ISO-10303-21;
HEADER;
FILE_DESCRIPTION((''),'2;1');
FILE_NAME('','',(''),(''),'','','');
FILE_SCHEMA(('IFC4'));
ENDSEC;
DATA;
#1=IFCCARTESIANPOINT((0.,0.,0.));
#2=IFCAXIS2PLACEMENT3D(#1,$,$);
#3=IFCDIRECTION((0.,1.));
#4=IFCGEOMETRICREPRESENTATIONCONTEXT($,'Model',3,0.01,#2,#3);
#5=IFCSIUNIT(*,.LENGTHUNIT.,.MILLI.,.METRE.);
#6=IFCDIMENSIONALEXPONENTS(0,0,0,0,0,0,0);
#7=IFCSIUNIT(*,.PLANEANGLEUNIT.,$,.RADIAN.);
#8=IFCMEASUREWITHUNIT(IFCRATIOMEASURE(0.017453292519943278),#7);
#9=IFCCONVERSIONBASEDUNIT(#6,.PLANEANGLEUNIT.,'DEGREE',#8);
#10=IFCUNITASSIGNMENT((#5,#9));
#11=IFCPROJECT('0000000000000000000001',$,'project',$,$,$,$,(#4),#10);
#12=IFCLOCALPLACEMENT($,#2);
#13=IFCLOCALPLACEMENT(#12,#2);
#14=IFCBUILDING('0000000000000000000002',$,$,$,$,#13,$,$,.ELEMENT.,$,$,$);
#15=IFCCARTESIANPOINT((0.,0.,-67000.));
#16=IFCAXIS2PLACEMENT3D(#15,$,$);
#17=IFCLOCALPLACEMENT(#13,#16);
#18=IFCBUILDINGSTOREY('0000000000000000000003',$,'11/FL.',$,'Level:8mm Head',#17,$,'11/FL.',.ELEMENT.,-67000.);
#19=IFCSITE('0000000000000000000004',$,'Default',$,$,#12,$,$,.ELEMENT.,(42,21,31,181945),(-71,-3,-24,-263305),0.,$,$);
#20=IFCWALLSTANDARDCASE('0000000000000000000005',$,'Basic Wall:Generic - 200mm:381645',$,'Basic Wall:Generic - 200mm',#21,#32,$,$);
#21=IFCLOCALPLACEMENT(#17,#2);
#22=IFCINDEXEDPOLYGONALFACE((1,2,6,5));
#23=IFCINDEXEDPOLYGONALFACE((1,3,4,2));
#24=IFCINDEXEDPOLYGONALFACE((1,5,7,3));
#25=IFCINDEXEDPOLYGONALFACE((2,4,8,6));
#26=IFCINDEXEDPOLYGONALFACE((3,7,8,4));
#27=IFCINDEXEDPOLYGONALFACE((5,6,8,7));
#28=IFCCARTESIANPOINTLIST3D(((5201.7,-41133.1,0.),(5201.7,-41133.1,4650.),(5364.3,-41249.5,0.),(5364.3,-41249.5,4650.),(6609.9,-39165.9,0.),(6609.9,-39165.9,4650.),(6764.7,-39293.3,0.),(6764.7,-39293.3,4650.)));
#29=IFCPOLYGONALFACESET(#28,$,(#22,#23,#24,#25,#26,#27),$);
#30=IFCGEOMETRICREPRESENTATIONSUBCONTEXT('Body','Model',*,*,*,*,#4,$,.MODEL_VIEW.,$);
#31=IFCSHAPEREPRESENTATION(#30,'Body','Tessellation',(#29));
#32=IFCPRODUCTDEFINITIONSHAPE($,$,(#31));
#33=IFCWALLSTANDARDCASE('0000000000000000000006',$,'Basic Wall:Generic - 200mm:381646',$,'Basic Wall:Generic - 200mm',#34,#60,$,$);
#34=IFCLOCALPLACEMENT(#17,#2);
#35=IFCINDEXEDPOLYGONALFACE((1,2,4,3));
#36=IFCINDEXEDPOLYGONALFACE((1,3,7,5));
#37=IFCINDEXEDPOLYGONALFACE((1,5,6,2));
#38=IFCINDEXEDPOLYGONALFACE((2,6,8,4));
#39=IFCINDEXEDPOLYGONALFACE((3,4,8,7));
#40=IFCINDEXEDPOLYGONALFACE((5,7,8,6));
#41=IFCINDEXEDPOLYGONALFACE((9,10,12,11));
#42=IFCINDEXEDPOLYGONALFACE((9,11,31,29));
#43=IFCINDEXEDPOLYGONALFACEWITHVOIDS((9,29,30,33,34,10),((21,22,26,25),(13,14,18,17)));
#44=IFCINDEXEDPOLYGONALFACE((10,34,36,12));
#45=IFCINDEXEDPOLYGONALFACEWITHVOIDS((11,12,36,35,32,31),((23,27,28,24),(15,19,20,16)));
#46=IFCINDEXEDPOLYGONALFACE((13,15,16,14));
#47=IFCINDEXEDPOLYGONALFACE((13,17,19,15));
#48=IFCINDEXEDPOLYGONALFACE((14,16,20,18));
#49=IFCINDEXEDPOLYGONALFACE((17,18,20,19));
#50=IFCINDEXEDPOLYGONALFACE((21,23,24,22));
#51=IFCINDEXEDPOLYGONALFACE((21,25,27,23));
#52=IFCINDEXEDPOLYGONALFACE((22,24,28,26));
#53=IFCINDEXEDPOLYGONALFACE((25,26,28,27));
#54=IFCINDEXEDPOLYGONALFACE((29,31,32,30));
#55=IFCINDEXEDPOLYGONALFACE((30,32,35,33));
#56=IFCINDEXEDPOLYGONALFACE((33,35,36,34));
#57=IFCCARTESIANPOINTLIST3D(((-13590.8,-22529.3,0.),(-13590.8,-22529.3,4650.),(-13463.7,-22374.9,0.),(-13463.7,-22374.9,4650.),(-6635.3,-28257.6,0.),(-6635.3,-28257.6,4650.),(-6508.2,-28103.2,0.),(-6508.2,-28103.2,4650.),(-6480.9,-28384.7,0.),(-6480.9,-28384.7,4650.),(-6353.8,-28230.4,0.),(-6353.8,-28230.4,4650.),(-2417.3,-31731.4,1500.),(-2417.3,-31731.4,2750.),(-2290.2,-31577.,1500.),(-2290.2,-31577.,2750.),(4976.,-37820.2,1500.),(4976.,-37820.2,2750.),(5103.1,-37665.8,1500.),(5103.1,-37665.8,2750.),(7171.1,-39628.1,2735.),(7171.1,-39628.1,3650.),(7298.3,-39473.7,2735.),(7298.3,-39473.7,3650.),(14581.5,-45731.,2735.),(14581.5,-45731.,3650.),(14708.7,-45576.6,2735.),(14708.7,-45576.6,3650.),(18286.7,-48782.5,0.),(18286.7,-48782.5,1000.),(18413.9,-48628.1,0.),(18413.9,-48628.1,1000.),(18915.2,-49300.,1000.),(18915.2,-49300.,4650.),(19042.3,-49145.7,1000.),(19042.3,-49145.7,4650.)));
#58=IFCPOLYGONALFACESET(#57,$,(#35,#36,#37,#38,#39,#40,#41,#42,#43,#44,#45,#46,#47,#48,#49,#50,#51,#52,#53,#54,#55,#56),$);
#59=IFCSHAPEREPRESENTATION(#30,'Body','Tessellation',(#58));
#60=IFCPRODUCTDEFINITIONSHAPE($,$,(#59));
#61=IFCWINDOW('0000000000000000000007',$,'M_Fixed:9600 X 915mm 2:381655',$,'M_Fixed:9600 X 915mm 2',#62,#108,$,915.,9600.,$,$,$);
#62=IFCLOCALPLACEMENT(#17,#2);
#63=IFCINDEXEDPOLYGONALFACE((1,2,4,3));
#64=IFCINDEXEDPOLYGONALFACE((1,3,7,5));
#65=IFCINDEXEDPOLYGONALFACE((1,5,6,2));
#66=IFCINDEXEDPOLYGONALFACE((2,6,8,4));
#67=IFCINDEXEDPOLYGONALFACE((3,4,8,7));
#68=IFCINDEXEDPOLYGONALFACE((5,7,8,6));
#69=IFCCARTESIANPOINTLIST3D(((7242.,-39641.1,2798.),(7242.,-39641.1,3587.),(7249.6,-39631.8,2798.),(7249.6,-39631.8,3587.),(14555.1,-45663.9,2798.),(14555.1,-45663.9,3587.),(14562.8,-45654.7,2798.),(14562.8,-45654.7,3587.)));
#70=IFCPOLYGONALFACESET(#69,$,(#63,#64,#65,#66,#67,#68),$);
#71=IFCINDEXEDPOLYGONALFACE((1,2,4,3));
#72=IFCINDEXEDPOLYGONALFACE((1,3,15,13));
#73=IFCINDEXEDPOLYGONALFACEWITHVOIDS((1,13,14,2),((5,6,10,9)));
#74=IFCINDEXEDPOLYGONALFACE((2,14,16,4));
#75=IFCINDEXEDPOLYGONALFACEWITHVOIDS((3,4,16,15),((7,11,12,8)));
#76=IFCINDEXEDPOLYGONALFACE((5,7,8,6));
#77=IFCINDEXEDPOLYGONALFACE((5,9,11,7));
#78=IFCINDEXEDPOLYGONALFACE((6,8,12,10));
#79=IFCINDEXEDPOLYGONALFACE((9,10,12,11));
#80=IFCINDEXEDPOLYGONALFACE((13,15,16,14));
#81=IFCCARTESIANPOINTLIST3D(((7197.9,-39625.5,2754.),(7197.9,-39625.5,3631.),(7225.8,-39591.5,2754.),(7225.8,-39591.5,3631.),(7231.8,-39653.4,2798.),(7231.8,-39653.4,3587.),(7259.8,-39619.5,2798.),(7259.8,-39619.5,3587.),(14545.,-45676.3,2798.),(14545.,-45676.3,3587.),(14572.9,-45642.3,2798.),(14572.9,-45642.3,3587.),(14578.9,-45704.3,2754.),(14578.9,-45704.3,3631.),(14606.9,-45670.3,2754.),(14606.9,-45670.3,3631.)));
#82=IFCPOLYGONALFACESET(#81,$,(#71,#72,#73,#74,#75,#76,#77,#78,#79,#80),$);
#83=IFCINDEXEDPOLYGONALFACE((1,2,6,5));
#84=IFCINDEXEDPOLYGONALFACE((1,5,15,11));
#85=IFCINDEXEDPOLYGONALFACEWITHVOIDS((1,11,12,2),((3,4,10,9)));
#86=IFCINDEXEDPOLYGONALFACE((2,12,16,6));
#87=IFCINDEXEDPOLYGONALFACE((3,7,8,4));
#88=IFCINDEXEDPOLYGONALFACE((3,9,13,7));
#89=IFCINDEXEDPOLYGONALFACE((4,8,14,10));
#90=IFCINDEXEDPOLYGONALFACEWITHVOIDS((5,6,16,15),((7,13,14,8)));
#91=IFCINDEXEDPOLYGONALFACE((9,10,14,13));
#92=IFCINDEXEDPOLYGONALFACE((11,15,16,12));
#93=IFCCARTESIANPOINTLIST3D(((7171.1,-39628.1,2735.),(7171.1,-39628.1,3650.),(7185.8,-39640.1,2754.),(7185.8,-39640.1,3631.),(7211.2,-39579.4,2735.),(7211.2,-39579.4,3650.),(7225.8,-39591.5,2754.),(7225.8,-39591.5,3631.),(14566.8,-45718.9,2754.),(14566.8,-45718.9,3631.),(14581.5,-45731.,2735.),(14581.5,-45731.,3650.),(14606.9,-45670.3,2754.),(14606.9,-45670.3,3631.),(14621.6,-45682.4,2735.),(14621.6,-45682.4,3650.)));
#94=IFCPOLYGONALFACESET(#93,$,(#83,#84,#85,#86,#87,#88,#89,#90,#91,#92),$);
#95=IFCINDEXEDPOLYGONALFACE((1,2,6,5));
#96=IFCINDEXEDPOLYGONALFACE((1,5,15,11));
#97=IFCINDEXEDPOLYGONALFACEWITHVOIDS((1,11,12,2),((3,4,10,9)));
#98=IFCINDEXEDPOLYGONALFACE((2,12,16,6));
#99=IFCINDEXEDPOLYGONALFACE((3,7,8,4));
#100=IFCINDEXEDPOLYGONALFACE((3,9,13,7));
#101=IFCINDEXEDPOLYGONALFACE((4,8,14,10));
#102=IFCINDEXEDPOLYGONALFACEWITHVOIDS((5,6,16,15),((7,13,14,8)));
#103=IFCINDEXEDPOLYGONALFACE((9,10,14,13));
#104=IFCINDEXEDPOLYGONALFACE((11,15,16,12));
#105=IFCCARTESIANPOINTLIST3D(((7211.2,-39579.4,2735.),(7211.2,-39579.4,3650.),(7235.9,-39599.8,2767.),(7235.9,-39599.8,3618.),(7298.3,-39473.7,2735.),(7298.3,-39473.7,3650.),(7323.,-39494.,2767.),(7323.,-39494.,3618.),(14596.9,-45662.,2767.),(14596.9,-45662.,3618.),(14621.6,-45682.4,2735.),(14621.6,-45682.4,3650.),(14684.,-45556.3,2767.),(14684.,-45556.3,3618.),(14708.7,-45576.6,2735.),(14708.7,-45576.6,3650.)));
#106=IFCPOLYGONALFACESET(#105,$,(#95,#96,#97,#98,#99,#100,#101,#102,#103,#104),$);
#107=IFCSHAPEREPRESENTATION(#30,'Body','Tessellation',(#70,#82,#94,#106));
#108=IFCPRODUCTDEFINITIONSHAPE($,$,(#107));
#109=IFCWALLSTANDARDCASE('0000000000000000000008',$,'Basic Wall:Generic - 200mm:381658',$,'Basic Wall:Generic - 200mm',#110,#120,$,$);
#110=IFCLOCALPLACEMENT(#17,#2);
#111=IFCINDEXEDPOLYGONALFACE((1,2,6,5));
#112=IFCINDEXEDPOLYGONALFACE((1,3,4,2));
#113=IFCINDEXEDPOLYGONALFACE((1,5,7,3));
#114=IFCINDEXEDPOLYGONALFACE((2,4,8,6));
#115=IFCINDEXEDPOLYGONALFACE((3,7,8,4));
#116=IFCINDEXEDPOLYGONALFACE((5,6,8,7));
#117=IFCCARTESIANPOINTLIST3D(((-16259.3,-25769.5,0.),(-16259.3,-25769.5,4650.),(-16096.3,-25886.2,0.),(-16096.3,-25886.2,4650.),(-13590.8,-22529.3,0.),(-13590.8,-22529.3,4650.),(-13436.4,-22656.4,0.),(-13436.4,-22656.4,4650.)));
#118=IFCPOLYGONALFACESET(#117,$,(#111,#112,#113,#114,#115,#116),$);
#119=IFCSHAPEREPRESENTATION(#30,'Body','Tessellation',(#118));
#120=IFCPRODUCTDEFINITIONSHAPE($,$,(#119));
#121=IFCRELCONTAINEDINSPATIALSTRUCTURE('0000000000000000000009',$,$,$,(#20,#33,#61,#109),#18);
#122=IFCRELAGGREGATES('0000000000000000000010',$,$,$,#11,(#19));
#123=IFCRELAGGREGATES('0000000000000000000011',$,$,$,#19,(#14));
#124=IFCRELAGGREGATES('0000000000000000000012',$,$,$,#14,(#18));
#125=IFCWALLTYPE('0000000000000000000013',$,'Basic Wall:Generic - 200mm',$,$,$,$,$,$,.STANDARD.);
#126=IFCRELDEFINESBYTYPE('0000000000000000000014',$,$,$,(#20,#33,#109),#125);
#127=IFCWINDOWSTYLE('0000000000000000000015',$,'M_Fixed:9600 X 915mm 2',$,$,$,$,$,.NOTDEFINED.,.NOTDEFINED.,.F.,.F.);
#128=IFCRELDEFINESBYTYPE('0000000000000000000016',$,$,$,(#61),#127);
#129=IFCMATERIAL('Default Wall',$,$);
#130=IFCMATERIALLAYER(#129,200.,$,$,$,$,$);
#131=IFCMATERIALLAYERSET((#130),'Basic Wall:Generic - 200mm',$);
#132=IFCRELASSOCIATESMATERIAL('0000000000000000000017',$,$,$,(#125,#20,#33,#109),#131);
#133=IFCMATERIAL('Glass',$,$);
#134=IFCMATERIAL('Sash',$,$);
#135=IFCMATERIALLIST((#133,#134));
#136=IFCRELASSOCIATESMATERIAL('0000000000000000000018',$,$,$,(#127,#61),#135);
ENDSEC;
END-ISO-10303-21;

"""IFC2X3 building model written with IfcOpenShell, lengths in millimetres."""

from ifc_helpers import new_model, entity, si_unit, converted_unit, direction, frame, frame_2d, origin, place, context, subcontext, project, spatial, polyline, rectangle, outline, extrude, source, transform, mapped, material, material_list, layer, layer_set, layer_usage, type_object, type_shapes, element, fill, save


model = new_model("IFC2X3")

# Units and contexts
model_context = context("Model", 3, precision=0.01, world=origin(), true_north=direction((0.0, 1.0)))
body_context = subcontext(model_context, "Body", "Model", "MODEL_VIEW")
ifc_project = project(units=[si_unit("LENGTHUNIT", "METRE", prefix="MILLI"), converted_unit("PLANEANGLEUNIT", "DEGREE", entity("IfcRatioMeasure", 0.017453292519943278), si_unit("PLANEANGLEUNIT", "RADIAN"), dimensions=[0, 0, 0, 0, 0, 0, 0])], contexts=[model_context])

# Site, building, storey
site_placement = place(None, origin())
site = spatial("IfcSite", under=ifc_project, at=site_placement, Name="Default", CompositionType="ELEMENT", RefLatitude=(42, 21, 31, 181945), RefLongitude=(-71, -3, -24, -263305), RefElevation=0.0)
building_placement = place(site_placement, origin())
building = spatial("IfcBuilding", under=site, at=building_placement, CompositionType="ELEMENT")
storey_placement = place(building_placement, frame((0.0, 0.0, -67000.0)))
storey = spatial("IfcBuildingStorey", under=building, at=storey_placement, Name="11/FL.", ObjectType="Level:8mm Head", LongName="11/FL.", CompositionType="ELEMENT", Elevation=-67000.0)

# Shared definitions
ifc_material_1 = material(Name="Default Wall")
ifc_layer = layer(ifc_material_1, 200.0)
ifc_layer_set = layer_set([ifc_layer], Name="Basic Wall:Generic - 200mm")
ifc_layer_usage = layer_usage(ifc_layer_set, "AXIS2", "NEGATIVE", 100.0)
wall_type = type_object("IfcWallType", Name="Basic Wall:Generic - 200mm", PredefinedType="STANDARD", material=ifc_layer_set)

# Shared definitions
ifc_material_2 = material(Name="Glass")
ifc_material_3 = material(Name="Sash")
ifc_material_list = material_list([ifc_material_2, ifc_material_3])

# Wall
wall_1_placement = place(storey_placement, frame((5283.0, -41191.3, 0.0), z_axis=(0.0, 0.0, 1.0), x_axis=(0.582098, 0.813119, 0.0)))
element("IfcWallStandardCase", 1, at=wall_1_placement, inside=storey, type_object=wall_type, material=ifc_layer_usage, Name="Basic Wall:Generic - 200mm:381645", ObjectType="Basic Wall:Generic - 200mm", context=body_context, shape_type="SweptSolid", body=[
    extrude(outline(polyline([(2405.7, -100.0), (2419.3, 100.0), (0.0, 100.0), (0.0, -100.0), (2405.7, -100.0)])), origin(), (0.0, 0.0, 1.0), 4650.0),
])

# Wall, openings, window
wall_2_placement = place(storey_placement, frame((-13527.2, -22452.1, 0.0), z_axis=(0.0, 0.0, 1.0), x_axis=(0.771917, -0.635723, 0.0)))
wall_2 = element("IfcWallStandardCase", 2, at=wall_2_placement, inside=storey, type_object=wall_type, material=ifc_layer_usage, Name="Basic Wall:Generic - 200mm:381646", ObjectType="Basic Wall:Generic - 200mm", context=body_context, shape_type="SweptSolid", body=[
    extrude(rectangle(XDim=42110.7, YDim=200.0, at=frame_2d((21055.3, 0.0), x_axis=(-1.0, 0.0))), origin(), (0.0, 0.0, 1.0), 4650.0),
])
opening_1_placement = place(storey_placement, frame((-13527.2, -22452.1, 0.0), z_axis=(0.0, 0.0, 1.0), x_axis=(0.771917, -0.635723, 0.0)))
element("IfcOpeningElement", 3, at=opening_1_placement, cuts=wall_2, ObjectType="Opening", context=body_context, shape_type="SweptSolid", body=[
    extrude(rectangle(XDim=4650.0, YDim=200.0, at=frame_2d((0.0, 0.0), x_axis=(1.0, 0.0))), frame((9210.7, 0.0, 2325.0), z_axis=(-1.0, 0.0, 0.0), x_axis=(0.0, 0.0, 1.0)), (0.0, 0.0, 1.0), 200.0),
])
opening_2_placement = place(wall_2_placement, origin())
element("IfcOpeningElement", 4, at=opening_2_placement, cuts=wall_2, ObjectType="Opening", context=body_context, shape_type="SweptSolid", body=[
    extrude(rectangle(XDim=1250.0, YDim=9577.8, at=frame_2d((0.0, 0.0), x_axis=(1.0, 0.0))), frame((19263.9, -100.0, 2125.0), z_axis=(0.0, 1.0, 0.0), x_axis=(0.0, 0.0, -1.0)), (0.0, 0.0, 1.0), 200.0),
])
opening_3_placement = place(wall_2_placement, frame((-3831.4, 25930.7, 0.0), z_axis=(0.0, 0.0, 1.0), x_axis=(0.771917, 0.635723, 0.0)))
element("IfcOpeningElement", 5, at=opening_3_placement, cuts=wall_2, ObjectType="Opening", context=body_context, shape_type="SweptSolid", body=[
    extrude(rectangle(XDim=1000.0, YDim=1010.1, at=frame_2d((0.0, 0.0), x_axis=(1.0, 0.0))), frame((18668.5, -49113.4, 500.0), z_axis=(0.635723, 0.771917, 0.0), x_axis=(0.0, 0.0, -1.0)), (0.0, 0.0, 1.0), 1012.7),
])
opening_4_placement = place(wall_2_placement, frame((36496.6, 100.0, 2735.0)))
opening_4 = element("IfcOpeningElement", 6, at=opening_4_placement, cuts=wall_2, ObjectType="Opening", context=body_context, shape_type="SweptSolid", body=[
    extrude(rectangle(XDim=915.0, YDim=9600.0, at=frame_2d((457.5, 4800.0), x_axis=(1.0, 0.0))), frame((0.0, 0.0, 0.0), z_axis=(0.0, -1.0, 0.0), x_axis=(0.0, 0.0, 1.0)), (0.0, 0.0, 1.0), 200.0),
])
window_style_1 = type_object("IfcWindowStyle", Name="M_Fixed:9600 X 915mm 2", ConstructionType="NOTDEFINED", OperationType="NOTDEFINED", ParameterTakesPrecedence=False, Sizeable=False, material=ifc_material_list)
shared_shape_1 = source(origin(), body_context, "Body", "SweptSolid", [
    extrude(rectangle(XDim=12.0, YDim=9474.0, at=frame_2d((0.0, 0.0), x_axis=(1.0, 0.0))), frame((4800.0, 159.0, 63.0), z_axis=(0.0, 0.0, 1.0), x_axis=(0.0, -1.0, 0.0)), (0.0, 0.0, 1.0), 789.0),
    extrude(outline(polyline([(-4781.0, -438.5), (4781.0, -438.5), (4781.0, 438.5), (-4781.0, 438.5), (-4781.0, -438.5)]), holes=[polyline([(-4737.0, -394.5), (-4737.0, 394.5), (4737.0, 394.5), (4737.0, -394.5), (-4737.0, -394.5)])]), frame((4800.0, 137.0, 457.5), z_axis=(0.0, 1.0, 0.0), x_axis=(1.0, 0.0, 0.0)), (0.0, 0.0, 1.0), 44.0),
    extrude(outline(polyline([(-4800.0, -457.5), (4800.0, -457.5), (4800.0, 457.5), (-4800.0, 457.5), (-4800.0, -457.5)]), holes=[polyline([(-4781.0, -438.5), (-4781.0, 438.5), (4781.0, 438.5), (4781.0, -438.5), (-4781.0, -438.5)])]), frame((4800.0, 137.0, 457.5), z_axis=(0.0, 1.0, 0.0), x_axis=(1.0, 0.0, 0.0)), (0.0, 0.0, 1.0), 63.0),
    extrude(outline(polyline([(-4800.0, -457.5), (4800.0, -457.5), (4800.0, 457.5), (-4800.0, 457.5), (-4800.0, -457.5)]), holes=[polyline([(-4768.0, -425.5), (-4768.0, 425.5), (4768.0, 425.5), (4768.0, -425.5), (-4768.0, -425.5)])]), frame((4800.0, 0.0, 457.5), z_axis=(0.0, 1.0, 0.0), x_axis=(1.0, 0.0, 0.0)), (0.0, 0.0, 1.0), 137.0),
])
type_shapes(window_style_1, [shared_shape_1])
window_1_placement = place(opening_4_placement, frame((0.0, 0.0, 0.0), z_axis=(0.0, 0.0, 1.0), x_axis=(-1.0, 0.0, 0.0)))
window_1 = element("IfcWindow", 7, at=window_1_placement, inside=storey, type_object=window_style_1, material=ifc_material_list, Name="M_Fixed:9600 X 915mm 2:381655", ObjectType="M_Fixed:9600 X 915mm 2", OverallHeight=915.0, OverallWidth=9600.0, context=body_context, shape_type="MappedRepresentation", body=[
    mapped(shared_shape_1, transform((0.0, 0.0, 0.0), scale=1.0)),
])
fill(opening_4, window_1)

# Wall
wall_3_placement = place(storey_placement, frame((-16182.1, -25833.1, 0.0), z_axis=(0.0, 0.0, 1.0), x_axis=(0.635723, 0.771917, 0.0)))
element("IfcWallStandardCase", 8, at=wall_3_placement, inside=storey, type_object=wall_type, material=ifc_layer_usage, Name="Basic Wall:Generic - 200mm:381658", ObjectType="Basic Wall:Generic - 200mm", context=body_context, shape_type="SweptSolid", body=[
    extrude(outline(polyline([(4197.6, -100.0), (4197.6, 100.0), (0.0, 100.0), (13.5, -100.0), (4197.6, -100.0)])), origin(), (0.0, 0.0, 1.0), 4650.0),
])

save(model, "model.ifc")
